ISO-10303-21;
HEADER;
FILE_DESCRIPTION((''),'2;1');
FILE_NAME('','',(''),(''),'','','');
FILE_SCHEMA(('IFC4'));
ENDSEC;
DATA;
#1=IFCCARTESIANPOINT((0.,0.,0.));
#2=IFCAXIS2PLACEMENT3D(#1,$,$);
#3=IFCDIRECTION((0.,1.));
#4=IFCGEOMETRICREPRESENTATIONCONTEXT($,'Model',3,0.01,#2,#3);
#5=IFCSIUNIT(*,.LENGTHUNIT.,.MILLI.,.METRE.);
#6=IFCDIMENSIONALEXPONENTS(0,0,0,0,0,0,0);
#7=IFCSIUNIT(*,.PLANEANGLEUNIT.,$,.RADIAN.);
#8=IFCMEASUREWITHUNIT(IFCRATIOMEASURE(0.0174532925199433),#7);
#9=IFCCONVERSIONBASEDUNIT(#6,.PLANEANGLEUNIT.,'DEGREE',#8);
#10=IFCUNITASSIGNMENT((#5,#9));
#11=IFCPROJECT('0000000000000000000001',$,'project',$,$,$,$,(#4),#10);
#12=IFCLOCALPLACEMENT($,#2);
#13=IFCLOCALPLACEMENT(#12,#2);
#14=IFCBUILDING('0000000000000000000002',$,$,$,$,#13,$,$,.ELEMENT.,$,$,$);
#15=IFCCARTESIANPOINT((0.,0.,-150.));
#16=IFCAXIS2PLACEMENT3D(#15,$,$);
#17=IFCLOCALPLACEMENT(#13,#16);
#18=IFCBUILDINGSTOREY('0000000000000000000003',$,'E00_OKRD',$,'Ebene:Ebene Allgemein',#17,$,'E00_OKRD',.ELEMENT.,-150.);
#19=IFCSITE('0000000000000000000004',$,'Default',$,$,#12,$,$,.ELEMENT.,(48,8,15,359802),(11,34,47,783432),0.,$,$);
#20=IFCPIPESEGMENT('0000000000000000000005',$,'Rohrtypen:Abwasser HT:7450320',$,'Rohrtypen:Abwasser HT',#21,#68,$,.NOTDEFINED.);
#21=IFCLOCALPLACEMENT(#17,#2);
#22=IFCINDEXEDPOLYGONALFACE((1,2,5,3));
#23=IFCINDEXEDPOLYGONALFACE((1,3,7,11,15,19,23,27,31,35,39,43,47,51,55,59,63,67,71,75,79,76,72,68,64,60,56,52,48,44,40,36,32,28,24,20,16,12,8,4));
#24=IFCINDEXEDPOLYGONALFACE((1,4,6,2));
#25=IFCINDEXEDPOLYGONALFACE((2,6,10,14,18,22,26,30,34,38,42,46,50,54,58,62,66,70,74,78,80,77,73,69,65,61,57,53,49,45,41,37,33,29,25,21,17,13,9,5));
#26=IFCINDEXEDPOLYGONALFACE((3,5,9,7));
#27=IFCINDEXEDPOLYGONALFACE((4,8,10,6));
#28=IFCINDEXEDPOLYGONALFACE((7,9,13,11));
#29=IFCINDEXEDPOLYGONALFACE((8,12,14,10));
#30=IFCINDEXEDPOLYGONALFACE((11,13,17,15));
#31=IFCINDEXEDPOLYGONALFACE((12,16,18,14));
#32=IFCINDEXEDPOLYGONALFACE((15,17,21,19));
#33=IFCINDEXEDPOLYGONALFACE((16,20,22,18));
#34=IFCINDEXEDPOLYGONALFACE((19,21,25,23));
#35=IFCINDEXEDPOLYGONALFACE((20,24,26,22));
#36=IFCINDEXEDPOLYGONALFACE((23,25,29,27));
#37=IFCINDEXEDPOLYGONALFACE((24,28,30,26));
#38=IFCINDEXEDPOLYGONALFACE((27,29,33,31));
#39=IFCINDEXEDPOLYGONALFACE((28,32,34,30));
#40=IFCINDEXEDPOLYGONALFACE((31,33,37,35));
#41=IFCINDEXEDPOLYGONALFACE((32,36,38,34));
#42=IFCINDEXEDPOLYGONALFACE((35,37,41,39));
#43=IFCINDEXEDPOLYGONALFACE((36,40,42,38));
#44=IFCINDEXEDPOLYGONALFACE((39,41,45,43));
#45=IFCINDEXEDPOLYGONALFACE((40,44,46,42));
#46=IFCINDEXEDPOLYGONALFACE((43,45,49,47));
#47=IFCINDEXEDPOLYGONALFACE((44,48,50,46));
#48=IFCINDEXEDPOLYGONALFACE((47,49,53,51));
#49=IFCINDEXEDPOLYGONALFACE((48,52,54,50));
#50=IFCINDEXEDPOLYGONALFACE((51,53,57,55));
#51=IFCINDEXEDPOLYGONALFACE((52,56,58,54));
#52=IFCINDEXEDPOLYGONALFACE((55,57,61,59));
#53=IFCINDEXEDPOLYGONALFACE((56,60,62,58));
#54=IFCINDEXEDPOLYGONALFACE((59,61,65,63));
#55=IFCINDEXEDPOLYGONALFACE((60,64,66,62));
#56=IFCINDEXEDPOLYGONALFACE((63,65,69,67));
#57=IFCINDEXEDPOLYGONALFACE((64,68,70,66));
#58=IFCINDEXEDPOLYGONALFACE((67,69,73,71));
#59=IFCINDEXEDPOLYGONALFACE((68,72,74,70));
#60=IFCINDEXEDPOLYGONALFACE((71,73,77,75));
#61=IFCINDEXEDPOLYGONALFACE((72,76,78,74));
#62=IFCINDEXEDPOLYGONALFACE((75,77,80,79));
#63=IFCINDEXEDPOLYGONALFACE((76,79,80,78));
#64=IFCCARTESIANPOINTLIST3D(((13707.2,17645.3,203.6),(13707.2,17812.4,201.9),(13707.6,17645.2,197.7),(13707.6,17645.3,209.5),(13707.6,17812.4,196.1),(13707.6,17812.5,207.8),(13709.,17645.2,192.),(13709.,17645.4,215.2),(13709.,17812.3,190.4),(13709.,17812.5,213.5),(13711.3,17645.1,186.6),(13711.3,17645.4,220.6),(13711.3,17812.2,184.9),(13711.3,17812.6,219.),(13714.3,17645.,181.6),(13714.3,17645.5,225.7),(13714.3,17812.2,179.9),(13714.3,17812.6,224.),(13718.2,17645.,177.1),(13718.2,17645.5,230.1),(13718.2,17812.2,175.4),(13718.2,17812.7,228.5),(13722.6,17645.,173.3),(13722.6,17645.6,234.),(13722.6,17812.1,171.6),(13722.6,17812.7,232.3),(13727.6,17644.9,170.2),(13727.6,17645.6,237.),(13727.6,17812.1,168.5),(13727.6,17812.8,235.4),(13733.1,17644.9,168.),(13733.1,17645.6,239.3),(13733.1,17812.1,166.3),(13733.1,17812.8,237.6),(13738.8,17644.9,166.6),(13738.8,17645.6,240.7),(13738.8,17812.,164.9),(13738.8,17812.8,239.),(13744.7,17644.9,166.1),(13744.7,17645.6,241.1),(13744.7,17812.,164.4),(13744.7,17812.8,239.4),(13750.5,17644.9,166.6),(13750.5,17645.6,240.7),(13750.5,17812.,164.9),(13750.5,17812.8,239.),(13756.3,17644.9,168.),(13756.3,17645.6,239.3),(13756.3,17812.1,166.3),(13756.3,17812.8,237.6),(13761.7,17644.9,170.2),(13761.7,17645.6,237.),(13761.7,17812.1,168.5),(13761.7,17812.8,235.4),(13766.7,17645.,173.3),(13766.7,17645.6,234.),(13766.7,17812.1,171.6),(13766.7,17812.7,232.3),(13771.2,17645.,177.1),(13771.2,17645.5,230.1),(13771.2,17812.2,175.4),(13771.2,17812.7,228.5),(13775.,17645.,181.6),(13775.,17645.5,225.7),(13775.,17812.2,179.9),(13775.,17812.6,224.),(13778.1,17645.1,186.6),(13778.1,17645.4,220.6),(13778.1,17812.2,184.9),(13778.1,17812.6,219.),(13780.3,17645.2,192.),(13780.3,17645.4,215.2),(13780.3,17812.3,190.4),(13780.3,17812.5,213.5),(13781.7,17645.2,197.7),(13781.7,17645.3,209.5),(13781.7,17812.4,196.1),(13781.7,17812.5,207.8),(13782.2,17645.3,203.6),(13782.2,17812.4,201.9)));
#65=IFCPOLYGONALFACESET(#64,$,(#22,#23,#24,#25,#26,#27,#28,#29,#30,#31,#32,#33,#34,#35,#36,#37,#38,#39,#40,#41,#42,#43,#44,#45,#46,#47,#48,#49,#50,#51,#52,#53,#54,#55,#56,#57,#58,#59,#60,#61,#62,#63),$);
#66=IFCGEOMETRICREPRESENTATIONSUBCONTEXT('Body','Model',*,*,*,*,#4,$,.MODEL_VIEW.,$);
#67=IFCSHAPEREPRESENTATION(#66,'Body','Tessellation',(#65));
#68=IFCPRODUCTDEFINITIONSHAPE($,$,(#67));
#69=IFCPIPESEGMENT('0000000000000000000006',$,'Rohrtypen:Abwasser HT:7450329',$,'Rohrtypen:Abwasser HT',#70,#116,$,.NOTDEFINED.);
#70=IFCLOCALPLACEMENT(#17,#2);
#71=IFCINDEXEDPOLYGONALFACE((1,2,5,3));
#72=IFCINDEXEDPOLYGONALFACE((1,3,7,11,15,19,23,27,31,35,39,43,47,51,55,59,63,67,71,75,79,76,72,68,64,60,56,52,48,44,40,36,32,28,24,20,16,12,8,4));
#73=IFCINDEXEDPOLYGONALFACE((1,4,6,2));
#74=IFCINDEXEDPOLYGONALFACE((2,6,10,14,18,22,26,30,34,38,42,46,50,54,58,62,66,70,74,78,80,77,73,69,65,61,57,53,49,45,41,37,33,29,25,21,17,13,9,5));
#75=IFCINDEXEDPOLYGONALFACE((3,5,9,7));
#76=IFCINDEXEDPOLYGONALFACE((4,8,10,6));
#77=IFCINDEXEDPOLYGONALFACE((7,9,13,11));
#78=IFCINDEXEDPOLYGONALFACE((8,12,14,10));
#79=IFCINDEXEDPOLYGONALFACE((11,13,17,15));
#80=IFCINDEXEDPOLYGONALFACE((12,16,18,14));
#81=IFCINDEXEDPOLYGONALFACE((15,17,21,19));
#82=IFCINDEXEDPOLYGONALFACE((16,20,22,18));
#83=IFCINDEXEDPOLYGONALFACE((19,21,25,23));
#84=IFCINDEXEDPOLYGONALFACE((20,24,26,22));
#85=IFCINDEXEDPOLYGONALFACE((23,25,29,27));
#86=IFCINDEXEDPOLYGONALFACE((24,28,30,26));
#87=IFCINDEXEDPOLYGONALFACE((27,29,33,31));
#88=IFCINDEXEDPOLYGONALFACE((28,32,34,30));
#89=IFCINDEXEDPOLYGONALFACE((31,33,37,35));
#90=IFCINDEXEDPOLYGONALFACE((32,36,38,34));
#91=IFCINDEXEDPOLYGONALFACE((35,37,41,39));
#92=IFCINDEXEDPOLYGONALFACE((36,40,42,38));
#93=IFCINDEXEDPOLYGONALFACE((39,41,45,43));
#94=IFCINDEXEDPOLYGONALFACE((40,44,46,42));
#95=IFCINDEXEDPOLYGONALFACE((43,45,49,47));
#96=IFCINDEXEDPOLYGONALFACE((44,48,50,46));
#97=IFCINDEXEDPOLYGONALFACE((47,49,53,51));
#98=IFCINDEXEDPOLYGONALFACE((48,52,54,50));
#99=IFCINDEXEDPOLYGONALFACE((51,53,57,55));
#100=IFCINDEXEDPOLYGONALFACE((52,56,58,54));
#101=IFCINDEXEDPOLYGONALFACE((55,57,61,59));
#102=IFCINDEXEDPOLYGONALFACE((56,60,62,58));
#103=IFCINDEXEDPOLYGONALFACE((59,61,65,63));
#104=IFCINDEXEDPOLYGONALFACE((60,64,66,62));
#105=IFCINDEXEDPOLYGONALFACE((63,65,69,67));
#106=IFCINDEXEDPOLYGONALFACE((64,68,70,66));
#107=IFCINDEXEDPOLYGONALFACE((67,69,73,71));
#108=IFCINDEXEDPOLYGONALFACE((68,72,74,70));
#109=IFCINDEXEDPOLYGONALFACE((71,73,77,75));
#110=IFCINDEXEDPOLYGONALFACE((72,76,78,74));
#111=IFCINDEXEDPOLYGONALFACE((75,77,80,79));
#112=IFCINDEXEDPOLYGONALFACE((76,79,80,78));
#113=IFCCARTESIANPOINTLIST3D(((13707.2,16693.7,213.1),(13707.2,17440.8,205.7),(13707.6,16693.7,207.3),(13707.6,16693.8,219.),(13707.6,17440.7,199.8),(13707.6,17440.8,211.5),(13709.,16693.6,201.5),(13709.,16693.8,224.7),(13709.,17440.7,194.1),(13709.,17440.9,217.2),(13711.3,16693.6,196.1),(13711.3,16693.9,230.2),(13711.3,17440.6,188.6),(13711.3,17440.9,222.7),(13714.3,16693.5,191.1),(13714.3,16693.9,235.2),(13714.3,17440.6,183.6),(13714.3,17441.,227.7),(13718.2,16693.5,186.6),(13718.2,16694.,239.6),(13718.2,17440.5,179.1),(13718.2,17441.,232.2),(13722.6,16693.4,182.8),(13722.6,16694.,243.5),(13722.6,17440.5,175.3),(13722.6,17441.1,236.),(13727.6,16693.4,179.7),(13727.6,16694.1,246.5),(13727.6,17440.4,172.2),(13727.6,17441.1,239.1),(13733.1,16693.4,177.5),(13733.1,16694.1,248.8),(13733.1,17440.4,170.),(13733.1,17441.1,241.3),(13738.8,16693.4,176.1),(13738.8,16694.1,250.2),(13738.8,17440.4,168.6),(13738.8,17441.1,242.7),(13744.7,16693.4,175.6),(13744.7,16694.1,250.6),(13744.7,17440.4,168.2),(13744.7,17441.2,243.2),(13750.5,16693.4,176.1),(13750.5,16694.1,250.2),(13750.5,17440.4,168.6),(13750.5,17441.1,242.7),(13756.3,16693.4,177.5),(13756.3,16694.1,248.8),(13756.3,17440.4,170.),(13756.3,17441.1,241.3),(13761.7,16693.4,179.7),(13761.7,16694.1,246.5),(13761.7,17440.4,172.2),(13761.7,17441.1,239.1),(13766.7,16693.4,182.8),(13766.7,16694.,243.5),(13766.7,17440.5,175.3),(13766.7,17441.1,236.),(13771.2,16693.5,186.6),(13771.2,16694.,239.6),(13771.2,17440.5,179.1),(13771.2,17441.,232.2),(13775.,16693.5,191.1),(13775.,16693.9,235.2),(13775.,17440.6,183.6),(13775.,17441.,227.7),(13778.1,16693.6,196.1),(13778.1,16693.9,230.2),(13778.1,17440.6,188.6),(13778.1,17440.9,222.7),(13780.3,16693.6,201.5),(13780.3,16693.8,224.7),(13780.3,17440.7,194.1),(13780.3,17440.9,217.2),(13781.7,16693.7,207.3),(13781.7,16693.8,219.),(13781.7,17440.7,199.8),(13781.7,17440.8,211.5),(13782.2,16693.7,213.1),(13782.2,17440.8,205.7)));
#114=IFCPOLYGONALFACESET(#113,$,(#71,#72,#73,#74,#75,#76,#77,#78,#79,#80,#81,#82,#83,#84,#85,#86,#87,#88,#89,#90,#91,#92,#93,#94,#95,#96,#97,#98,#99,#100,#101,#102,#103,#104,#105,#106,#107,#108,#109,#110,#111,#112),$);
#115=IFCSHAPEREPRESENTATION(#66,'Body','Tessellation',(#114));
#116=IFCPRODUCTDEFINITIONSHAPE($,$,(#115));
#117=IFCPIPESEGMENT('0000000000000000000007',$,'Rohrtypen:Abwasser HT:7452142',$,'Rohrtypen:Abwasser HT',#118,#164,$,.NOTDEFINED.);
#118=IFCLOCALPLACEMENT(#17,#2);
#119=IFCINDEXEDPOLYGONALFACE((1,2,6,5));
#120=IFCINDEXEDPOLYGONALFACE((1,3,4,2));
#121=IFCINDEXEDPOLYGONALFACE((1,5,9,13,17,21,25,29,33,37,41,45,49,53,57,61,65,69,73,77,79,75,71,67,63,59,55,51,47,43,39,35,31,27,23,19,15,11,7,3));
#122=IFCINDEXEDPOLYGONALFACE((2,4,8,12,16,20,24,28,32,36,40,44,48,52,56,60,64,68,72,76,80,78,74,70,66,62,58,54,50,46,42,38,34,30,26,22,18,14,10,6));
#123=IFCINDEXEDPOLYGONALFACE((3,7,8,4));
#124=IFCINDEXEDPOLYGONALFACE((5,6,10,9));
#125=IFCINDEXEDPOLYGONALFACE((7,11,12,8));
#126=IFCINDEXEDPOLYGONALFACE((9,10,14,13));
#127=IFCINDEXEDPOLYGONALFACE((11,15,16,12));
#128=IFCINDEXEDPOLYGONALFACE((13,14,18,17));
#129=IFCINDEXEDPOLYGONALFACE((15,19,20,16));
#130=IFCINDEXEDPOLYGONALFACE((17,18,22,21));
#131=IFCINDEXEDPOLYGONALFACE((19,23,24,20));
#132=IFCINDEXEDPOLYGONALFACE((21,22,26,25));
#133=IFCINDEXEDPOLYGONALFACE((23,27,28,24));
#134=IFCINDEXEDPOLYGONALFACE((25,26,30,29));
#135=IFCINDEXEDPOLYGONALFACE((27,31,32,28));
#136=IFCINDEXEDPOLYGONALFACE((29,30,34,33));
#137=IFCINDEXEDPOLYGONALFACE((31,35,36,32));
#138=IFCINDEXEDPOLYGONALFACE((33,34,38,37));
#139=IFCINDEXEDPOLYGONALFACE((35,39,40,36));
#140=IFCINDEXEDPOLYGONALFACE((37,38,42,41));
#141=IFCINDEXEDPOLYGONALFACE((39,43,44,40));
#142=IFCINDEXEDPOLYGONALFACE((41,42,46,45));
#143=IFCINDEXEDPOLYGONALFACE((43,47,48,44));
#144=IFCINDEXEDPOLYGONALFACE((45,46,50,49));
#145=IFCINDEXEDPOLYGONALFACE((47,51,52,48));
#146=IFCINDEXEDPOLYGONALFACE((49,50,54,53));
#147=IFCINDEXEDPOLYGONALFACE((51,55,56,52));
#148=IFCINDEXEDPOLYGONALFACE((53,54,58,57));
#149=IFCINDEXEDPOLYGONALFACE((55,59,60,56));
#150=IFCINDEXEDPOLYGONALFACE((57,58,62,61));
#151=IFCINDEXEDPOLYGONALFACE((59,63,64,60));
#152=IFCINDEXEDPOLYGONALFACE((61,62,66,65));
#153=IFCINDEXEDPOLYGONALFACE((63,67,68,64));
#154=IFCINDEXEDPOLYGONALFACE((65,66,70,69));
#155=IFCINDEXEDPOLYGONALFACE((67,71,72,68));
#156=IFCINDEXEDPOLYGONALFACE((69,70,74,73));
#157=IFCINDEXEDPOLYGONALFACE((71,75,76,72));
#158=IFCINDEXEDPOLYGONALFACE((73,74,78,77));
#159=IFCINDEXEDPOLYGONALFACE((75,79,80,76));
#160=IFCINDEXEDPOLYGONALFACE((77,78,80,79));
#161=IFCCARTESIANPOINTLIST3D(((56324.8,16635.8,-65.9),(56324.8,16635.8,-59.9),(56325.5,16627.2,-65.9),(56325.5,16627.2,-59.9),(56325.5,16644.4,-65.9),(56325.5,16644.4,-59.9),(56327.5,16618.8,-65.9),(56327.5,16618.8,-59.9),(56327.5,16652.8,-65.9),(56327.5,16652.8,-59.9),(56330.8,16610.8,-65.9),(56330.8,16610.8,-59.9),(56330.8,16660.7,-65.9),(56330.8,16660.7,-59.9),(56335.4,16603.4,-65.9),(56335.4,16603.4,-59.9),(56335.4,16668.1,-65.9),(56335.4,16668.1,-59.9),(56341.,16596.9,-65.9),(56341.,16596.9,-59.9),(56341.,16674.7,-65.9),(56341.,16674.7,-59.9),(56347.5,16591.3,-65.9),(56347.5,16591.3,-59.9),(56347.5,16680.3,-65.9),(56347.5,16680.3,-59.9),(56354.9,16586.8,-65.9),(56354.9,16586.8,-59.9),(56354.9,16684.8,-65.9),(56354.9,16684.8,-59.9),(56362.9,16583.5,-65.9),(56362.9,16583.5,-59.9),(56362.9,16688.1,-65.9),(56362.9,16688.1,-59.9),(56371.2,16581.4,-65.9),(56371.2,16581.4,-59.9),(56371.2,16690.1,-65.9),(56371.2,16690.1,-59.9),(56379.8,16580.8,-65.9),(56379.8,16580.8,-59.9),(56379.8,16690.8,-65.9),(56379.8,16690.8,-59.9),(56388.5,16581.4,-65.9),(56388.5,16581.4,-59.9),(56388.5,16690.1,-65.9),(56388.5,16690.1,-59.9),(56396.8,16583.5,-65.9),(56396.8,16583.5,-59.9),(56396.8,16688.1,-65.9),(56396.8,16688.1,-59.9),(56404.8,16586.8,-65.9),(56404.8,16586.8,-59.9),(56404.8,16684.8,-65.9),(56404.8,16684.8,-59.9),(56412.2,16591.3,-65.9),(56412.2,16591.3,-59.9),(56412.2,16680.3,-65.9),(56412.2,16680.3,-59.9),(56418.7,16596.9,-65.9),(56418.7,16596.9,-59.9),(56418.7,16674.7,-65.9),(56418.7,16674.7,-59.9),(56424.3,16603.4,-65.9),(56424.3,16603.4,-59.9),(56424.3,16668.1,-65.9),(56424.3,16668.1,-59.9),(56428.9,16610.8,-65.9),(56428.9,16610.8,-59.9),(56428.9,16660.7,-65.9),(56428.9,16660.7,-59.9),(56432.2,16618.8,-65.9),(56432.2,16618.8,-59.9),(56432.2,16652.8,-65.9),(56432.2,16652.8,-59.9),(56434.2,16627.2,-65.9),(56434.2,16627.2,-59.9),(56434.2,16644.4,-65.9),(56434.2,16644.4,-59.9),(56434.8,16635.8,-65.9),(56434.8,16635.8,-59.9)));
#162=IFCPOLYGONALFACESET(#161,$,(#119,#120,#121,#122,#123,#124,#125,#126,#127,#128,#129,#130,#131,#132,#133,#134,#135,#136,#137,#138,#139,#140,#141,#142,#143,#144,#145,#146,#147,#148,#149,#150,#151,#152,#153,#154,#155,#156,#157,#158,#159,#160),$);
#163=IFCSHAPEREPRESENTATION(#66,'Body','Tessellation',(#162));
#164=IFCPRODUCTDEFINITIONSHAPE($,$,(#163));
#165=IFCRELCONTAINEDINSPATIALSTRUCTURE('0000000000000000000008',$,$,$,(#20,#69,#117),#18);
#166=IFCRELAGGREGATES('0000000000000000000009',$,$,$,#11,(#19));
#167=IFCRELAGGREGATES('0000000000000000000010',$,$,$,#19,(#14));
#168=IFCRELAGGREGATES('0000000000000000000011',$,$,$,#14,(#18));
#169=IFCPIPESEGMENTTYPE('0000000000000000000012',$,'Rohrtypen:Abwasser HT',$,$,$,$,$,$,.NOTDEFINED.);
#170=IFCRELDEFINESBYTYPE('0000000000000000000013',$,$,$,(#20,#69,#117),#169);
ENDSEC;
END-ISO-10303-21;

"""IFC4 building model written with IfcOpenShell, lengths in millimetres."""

from ifc_helpers import new_model, entity, si_unit, converted_unit, direction, frame, origin, place, context, subcontext, project, spatial, indexed_curve, outline, extrude, type_object, element, save


model = new_model("IFC4")

# Units and contexts
model_context = context("Model", 3, precision=0.01, world=origin(), true_north=direction((0.0, 1.0)))
body_context = subcontext(model_context, "Body", "Model", "MODEL_VIEW")
ifc_project = project(units=[si_unit("LENGTHUNIT", "METRE", prefix="MILLI"), converted_unit("PLANEANGLEUNIT", "DEGREE", entity("IfcRatioMeasure", 0.0174532925199433), si_unit("PLANEANGLEUNIT", "RADIAN"), dimensions=[0, 0, 0, 0, 0, 0, 0])], contexts=[model_context])

# Site, building, storey
site_placement = place(None, origin())
site = spatial("IfcSite", under=ifc_project, at=site_placement, Name="Default", CompositionType="ELEMENT", RefLatitude=(48, 8, 15, 359802), RefLongitude=(11, 34, 47, 783432), RefElevation=0.0)
building_placement = place(site_placement, origin())
building = spatial("IfcBuilding", under=site, at=building_placement, CompositionType="ELEMENT")
storey_placement = place(building_placement, frame((0.0, 0.0, -150.0)))
storey = spatial("IfcBuildingStorey", under=building, at=storey_placement, Name="E00_OKRD", ObjectType="Ebene:Ebene Allgemein", LongName="E00_OKRD", CompositionType="ELEMENT", Elevation=-150.0)

# Pipe segments
pipe_segment_type_1 = type_object("IfcPipeSegmentType", Name="Rohrtypen:Abwasser HT", PredefinedType="NOTDEFINED")
pipe_segment_1_placement = place(storey_placement, origin())
element("IfcPipeSegment", 1, at=pipe_segment_1_placement, inside=storey, type_object=pipe_segment_type_1, Name="Rohrtypen:Abwasser HT:7450320", ObjectType="Rohrtypen:Abwasser HT", PredefinedType="NOTDEFINED", context=body_context, shape_type="SweptSolid", body=[
    extrude(outline(indexed_curve([(37.5, 0.0), (37.0, 5.9), (35.7, 11.6), (33.4, 17.0), (30.3, 22.0), (26.5, 26.5), (22.0, 30.3), (17.0, 33.4), (11.6, 35.7), (5.9, 37.0), (0.0, 37.5), (-5.9, 37.0), (-11.6, 35.7), (-17.0, 33.4), (-22.0, 30.3), (-26.5, 26.5), (-30.3, 22.0), (-33.4, 17.0), (-35.7, 11.6), (-37.0, 5.9), (-37.5, 0.0), (-37.0, -5.9), (-35.7, -11.6), (-33.4, -17.0), (-30.3, -22.0), (-26.5, -26.5), (-22.0, -30.3), (-17.0, -33.4), (-11.6, -35.7), (-5.9, -37.0), (0.0, -37.5), (5.9, -37.0), (11.6, -35.7), (17.0, -33.4), (22.0, -30.3), (26.5, -26.5), (30.3, -22.0), (33.4, -17.0), (35.7, -11.6), (37.0, -5.9), (37.5, 0.0)], self_intersect=False)), frame((13744.7, 17645.3, 203.6), z_axis=(0.0, 0.99995, -0.01), x_axis=(1.0, 0.0, 0.0)), (0.0, 0.0, 1.0), 167.2),
])
pipe_segment_2_placement = place(storey_placement, origin())
element("IfcPipeSegment", 2, at=pipe_segment_2_placement, inside=storey, type_object=pipe_segment_type_1, Name="Rohrtypen:Abwasser HT:7450329", ObjectType="Rohrtypen:Abwasser HT", PredefinedType="NOTDEFINED", context=body_context, shape_type="SweptSolid", body=[
    extrude(outline(indexed_curve([(37.5, 0.0), (37.0, 5.9), (35.7, 11.6), (33.4, 17.0), (30.3, 22.0), (26.5, 26.5), (22.0, 30.3), (17.0, 33.4), (11.6, 35.7), (5.9, 37.0), (0.0, 37.5), (-5.9, 37.0), (-11.6, 35.7), (-17.0, 33.4), (-22.0, 30.3), (-26.5, 26.5), (-30.3, 22.0), (-33.4, 17.0), (-35.7, 11.6), (-37.0, 5.9), (-37.5, 0.0), (-37.0, -5.9), (-35.7, -11.6), (-33.4, -17.0), (-30.3, -22.0), (-26.5, -26.5), (-22.0, -30.3), (-17.0, -33.4), (-11.6, -35.7), (-5.9, -37.0), (0.0, -37.5), (5.9, -37.0), (11.6, -35.7), (17.0, -33.4), (22.0, -30.3), (26.5, -26.5), (30.3, -22.0), (33.4, -17.0), (35.7, -11.6), (37.0, -5.9), (37.5, 0.0)], self_intersect=False)), frame((13744.7, 17440.8, 205.7), z_axis=(0.0, -0.99995, 0.01), x_axis=(1.0, 0.0, 0.0)), (0.0, 0.0, 1.0), 747.1),
])
pipe_segment_3_placement = place(storey_placement, origin())
element("IfcPipeSegment", 3, at=pipe_segment_3_placement, inside=storey, type_object=pipe_segment_type_1, Name="Rohrtypen:Abwasser HT:7452142", ObjectType="Rohrtypen:Abwasser HT", PredefinedType="NOTDEFINED", context=body_context, shape_type="SweptSolid", body=[
    extrude(outline(indexed_curve([(55.0, 0.0), (54.3, 8.6), (52.3, 17.0), (49.0, 25.0), (44.5, 32.3), (38.9, 38.9), (32.3, 44.5), (25.0, 49.0), (17.0, 52.3), (8.6, 54.3), (0.0, 55.0), (-8.6, 54.3), (-17.0, 52.3), (-25.0, 49.0), (-32.3, 44.5), (-38.9, 38.9), (-44.5, 32.3), (-49.0, 25.0), (-52.3, 17.0), (-54.3, 8.6), (-55.0, 0.0), (-54.3, -8.6), (-52.3, -17.0), (-49.0, -25.0), (-44.5, -32.3), (-38.9, -38.9), (-32.3, -44.5), (-25.0, -49.0), (-17.0, -52.3), (-8.6, -54.3), (0.0, -55.0), (8.6, -54.3), (17.0, -52.3), (25.0, -49.0), (32.3, -44.5), (38.9, -38.9), (44.5, -32.3), (49.0, -25.0), (52.3, -17.0), (54.3, -8.6), (55.0, 0.0)], self_intersect=False)), frame((56379.8, 16635.8, -65.9)), (0.0, 0.0, 1.0), 5.9),
])

save(model, "model.ifc")
